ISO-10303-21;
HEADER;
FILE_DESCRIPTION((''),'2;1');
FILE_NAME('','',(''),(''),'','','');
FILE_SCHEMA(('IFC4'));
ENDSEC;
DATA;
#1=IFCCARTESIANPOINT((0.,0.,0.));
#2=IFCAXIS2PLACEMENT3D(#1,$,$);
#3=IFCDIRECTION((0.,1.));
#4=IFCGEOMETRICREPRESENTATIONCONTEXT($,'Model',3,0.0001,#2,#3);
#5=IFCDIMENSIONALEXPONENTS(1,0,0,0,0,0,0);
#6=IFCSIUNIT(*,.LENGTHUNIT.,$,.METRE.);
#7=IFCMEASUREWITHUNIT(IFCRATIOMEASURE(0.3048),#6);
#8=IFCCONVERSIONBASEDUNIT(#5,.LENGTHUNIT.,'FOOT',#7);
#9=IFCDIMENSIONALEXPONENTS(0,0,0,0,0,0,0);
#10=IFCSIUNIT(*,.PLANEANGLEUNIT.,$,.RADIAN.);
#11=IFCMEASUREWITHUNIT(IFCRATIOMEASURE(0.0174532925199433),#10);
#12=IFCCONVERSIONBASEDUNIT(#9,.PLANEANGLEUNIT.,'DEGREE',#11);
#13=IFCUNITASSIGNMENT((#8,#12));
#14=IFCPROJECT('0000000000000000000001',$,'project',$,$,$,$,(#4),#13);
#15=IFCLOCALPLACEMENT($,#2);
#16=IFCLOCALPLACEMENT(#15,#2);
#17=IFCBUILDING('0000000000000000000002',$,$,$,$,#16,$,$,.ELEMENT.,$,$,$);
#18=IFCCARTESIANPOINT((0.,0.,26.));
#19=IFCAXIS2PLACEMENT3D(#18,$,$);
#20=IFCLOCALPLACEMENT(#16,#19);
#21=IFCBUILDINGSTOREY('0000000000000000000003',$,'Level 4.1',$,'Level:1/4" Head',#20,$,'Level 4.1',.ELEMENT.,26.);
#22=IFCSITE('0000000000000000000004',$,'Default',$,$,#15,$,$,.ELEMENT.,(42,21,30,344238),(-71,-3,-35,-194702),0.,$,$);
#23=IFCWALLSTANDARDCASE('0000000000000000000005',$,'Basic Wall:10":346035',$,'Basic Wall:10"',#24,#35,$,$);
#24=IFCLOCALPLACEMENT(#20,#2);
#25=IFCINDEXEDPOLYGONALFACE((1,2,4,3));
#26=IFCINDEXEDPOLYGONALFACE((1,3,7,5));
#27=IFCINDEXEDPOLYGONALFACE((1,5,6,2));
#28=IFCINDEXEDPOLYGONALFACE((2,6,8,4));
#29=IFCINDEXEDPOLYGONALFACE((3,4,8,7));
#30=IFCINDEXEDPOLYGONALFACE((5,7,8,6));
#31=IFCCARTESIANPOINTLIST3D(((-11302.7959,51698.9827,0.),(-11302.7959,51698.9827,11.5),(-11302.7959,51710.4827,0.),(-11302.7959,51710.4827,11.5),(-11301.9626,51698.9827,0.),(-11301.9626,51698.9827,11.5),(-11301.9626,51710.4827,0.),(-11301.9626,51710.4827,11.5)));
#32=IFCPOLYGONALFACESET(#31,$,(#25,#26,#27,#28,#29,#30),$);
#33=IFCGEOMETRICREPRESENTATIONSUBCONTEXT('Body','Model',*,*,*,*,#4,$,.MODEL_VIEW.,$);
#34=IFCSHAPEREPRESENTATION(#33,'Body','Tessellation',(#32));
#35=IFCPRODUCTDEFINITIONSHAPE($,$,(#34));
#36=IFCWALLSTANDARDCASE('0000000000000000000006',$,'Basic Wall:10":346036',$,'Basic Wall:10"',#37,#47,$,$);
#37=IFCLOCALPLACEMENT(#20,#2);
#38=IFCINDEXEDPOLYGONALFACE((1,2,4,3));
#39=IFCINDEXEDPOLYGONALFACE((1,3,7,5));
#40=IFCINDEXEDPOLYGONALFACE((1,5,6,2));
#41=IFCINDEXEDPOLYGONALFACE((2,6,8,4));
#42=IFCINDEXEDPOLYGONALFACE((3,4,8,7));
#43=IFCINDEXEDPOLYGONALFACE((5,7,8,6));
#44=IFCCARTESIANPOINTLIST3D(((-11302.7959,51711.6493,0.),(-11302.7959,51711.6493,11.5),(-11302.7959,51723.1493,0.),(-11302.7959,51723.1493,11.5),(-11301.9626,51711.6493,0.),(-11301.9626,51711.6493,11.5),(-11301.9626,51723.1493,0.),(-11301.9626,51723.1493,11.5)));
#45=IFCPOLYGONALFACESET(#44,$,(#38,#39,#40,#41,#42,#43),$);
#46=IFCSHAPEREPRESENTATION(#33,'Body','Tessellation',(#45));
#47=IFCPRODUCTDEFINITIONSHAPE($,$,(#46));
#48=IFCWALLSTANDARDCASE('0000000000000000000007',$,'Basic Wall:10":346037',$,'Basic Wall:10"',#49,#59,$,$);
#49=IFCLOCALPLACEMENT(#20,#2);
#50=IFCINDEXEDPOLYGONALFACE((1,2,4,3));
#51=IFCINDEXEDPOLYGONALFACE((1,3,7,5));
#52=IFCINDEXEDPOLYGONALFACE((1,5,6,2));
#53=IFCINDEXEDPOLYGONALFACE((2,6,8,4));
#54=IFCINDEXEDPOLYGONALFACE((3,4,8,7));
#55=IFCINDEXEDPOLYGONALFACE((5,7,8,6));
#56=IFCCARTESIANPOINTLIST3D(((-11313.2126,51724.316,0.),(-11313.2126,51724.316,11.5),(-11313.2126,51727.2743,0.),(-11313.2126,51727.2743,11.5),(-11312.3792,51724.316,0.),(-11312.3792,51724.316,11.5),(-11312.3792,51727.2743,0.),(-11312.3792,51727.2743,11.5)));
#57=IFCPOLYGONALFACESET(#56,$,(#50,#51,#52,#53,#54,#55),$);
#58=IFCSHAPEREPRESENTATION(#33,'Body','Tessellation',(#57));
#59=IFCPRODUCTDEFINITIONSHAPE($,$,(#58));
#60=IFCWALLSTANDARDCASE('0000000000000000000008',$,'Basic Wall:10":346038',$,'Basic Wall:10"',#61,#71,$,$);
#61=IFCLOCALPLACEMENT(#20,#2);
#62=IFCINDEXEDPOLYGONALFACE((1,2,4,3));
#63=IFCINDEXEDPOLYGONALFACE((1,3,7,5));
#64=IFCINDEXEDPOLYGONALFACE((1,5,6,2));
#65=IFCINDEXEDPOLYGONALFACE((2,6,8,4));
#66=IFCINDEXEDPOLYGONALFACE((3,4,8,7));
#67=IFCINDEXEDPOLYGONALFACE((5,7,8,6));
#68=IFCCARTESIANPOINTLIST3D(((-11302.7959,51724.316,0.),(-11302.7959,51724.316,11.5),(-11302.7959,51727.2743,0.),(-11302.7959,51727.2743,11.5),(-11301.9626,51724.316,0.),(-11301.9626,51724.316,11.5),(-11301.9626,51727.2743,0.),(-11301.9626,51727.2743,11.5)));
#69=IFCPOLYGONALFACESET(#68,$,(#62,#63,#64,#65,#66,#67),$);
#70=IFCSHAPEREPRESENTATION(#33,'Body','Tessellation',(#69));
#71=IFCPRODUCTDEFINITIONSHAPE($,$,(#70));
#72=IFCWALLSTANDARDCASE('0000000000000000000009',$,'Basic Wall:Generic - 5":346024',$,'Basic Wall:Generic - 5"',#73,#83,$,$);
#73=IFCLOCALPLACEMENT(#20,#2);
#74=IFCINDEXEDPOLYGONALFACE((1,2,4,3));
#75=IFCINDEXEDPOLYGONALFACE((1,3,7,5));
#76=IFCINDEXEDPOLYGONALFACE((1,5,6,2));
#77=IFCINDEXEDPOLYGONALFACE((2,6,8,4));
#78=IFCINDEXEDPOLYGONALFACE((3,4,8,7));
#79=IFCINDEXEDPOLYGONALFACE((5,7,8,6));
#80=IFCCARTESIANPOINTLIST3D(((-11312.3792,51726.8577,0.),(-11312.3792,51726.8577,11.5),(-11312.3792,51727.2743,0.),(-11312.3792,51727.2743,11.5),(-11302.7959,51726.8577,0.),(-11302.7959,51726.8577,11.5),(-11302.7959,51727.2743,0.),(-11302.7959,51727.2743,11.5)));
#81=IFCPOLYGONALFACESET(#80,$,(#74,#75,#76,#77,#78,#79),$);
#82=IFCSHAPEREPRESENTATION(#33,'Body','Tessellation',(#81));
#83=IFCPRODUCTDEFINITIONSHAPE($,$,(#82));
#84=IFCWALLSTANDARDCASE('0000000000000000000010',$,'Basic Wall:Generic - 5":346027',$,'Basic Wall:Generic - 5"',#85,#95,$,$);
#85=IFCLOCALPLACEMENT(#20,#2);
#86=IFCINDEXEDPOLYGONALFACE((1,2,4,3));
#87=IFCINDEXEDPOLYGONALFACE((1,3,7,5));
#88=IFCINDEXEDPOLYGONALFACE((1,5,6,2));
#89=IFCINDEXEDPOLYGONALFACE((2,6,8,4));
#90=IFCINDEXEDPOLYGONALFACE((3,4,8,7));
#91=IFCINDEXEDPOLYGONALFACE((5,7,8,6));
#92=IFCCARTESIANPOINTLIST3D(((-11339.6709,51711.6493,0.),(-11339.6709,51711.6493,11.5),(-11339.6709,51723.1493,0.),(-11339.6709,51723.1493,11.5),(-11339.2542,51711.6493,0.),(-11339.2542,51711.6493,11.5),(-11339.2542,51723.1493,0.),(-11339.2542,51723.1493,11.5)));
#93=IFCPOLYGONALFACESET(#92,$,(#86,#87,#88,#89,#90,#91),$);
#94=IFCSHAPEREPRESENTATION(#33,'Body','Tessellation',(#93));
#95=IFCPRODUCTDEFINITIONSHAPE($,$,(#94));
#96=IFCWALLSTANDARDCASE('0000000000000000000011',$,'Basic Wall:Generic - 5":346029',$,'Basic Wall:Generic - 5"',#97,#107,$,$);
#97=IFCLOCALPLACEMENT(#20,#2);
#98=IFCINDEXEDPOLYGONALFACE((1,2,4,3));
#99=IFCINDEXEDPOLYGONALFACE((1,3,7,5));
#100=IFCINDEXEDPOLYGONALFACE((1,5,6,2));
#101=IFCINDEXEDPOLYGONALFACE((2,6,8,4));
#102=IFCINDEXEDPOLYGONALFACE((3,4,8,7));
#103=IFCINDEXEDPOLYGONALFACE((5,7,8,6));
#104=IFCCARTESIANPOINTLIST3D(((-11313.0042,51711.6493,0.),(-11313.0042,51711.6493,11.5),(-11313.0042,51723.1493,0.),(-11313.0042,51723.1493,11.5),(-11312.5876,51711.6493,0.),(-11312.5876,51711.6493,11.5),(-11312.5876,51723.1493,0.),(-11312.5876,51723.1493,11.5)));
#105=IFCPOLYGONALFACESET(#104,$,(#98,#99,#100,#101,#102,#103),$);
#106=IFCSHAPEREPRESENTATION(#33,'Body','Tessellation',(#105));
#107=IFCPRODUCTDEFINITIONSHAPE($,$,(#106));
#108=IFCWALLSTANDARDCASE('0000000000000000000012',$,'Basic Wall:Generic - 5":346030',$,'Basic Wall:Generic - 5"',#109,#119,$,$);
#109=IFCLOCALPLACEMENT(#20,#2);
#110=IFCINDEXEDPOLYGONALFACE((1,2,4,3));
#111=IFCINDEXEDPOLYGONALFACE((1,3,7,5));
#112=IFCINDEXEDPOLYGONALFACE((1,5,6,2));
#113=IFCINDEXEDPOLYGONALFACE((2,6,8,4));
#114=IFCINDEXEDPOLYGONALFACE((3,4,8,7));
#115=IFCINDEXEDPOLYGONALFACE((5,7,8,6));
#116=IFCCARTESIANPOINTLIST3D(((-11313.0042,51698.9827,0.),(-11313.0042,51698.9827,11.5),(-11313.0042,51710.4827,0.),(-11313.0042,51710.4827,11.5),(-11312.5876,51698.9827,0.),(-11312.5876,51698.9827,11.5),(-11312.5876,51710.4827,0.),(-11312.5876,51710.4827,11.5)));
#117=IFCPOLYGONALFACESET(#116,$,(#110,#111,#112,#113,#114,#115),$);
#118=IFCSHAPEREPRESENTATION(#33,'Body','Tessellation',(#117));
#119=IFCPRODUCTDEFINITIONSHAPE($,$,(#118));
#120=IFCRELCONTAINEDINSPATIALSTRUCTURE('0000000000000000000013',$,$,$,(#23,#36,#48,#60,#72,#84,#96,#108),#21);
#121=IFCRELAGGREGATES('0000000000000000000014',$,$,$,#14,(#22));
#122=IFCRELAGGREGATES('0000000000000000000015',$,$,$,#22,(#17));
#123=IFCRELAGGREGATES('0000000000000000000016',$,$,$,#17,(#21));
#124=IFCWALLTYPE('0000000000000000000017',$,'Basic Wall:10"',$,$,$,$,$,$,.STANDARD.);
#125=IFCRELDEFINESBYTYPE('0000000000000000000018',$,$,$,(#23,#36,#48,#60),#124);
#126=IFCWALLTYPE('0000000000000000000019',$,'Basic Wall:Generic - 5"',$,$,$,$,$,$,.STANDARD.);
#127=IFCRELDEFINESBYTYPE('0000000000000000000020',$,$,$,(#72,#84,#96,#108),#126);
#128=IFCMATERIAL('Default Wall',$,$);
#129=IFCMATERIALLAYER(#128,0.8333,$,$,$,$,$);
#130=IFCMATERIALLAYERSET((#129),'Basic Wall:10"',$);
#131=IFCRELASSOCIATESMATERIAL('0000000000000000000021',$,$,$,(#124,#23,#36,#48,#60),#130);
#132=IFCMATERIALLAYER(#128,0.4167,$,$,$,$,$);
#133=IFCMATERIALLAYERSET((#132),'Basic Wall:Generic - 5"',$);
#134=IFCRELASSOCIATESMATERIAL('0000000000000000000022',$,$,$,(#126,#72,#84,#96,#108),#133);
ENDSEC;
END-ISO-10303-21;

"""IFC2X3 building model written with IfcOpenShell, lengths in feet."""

from ifc_helpers import new_model, entity, si_unit, converted_unit, direction, frame, frame_2d, origin, place, context, subcontext, project, spatial, rectangle, extrude, material, layer, layer_set, layer_usage, type_object, element, save


model = new_model("IFC2X3")

# Units and contexts
model_context = context("Model", 3, precision=0.0001, world=origin(), true_north=direction((0.0, 1.0)))
body_context = subcontext(model_context, "Body", "Model", "MODEL_VIEW")
ifc_project = project(units=[converted_unit("LENGTHUNIT", "FOOT", entity("IfcRatioMeasure", 0.3048), si_unit("LENGTHUNIT", "METRE"), dimensions=[1, 0, 0, 0, 0, 0, 0]), converted_unit("PLANEANGLEUNIT", "DEGREE", entity("IfcRatioMeasure", 0.0174532925199433), si_unit("PLANEANGLEUNIT", "RADIAN"), dimensions=[0, 0, 0, 0, 0, 0, 0])], contexts=[model_context])

# Site, building, storey
site_placement = place(None, origin())
site = spatial("IfcSite", under=ifc_project, at=site_placement, Name="Default", CompositionType="ELEMENT", RefLatitude=(42, 21, 30, 344238), RefLongitude=(-71, -3, -35, -194702), RefElevation=0.0)
building_placement = place(site_placement, origin())
building = spatial("IfcBuilding", under=site, at=building_placement, CompositionType="ELEMENT")
storey_placement = place(building_placement, frame((0.0, 0.0, 26.0)))
storey = spatial("IfcBuildingStorey", under=building, at=storey_placement, Name="Level 4.1", ObjectType="Level:1/4\" Head", LongName="Level 4.1", CompositionType="ELEMENT", Elevation=26.0)

# Walls
ifc_material_1 = material(Name="Default Wall")
ifc_layer_1 = layer(ifc_material_1, 0.8333)
ifc_layer_set_1 = layer_set([ifc_layer_1], Name="Basic Wall:10\"")
ifc_layer_usage_1 = layer_usage(ifc_layer_set_1, "AXIS2", "NEGATIVE", 0.4167)
wall_type_1 = type_object("IfcWallType", Name="Basic Wall:10\"", PredefinedType="STANDARD", material=ifc_layer_set_1)
wall_1_placement = place(storey_placement, frame((-11302.3792, 51698.9827, 0.0), z_axis=(0.0, 0.0, 1.0), x_axis=(0.0, 1.0, 0.0)))
element("IfcWallStandardCase", 1, at=wall_1_placement, inside=storey, type_object=wall_type_1, material=ifc_layer_usage_1, Name="Basic Wall:10\":346035", ObjectType="Basic Wall:10\"", context=body_context, shape_type="SweptSolid", body=[
    extrude(rectangle(XDim=11.5, YDim=0.8333, at=frame_2d((5.75, 0.0), x_axis=(-1.0, 0.0))), origin(), (0.0, 0.0, 1.0), 11.5),
])
ifc_layer_usage_2 = layer_usage(ifc_layer_set_1, "AXIS2", "NEGATIVE", 0.4167)
wall_2_placement = place(storey_placement, frame((-11302.3792, 51711.6493, 0.0), z_axis=(0.0, 0.0, 1.0), x_axis=(0.0, 1.0, 0.0)))
element("IfcWallStandardCase", 2, at=wall_2_placement, inside=storey, type_object=wall_type_1, material=ifc_layer_usage_2, Name="Basic Wall:10\":346036", ObjectType="Basic Wall:10\"", context=body_context, shape_type="SweptSolid", body=[
    extrude(rectangle(XDim=11.5, YDim=0.8333, at=frame_2d((5.75, 0.0), x_axis=(-1.0, 0.0))), origin(), (0.0, 0.0, 1.0), 11.5),
])
ifc_layer_usage_3 = layer_usage(ifc_layer_set_1, "AXIS2", "NEGATIVE", 0.4167)
wall_3_placement = place(storey_placement, frame((-11312.7959, 51724.316, 0.0), z_axis=(0.0, 0.0, 1.0), x_axis=(0.0, 1.0, 0.0)))
element("IfcWallStandardCase", 3, at=wall_3_placement, inside=storey, type_object=wall_type_1, material=ifc_layer_usage_3, Name="Basic Wall:10\":346037", ObjectType="Basic Wall:10\"", context=body_context, shape_type="SweptSolid", body=[
    extrude(rectangle(XDim=2.9583, YDim=0.8333, at=frame_2d((1.4792, 0.0), x_axis=(-1.0, 0.0))), origin(), (0.0, 0.0, 1.0), 11.5),
])
ifc_layer_usage_4 = layer_usage(ifc_layer_set_1, "AXIS2", "NEGATIVE", 0.4167)
wall_4_placement = place(storey_placement, frame((-11302.3792, 51724.316, 0.0), z_axis=(0.0, 0.0, 1.0), x_axis=(0.0, 1.0, 0.0)))
element("IfcWallStandardCase", 4, at=wall_4_placement, inside=storey, type_object=wall_type_1, material=ifc_layer_usage_4, Name="Basic Wall:10\":346038", ObjectType="Basic Wall:10\"", context=body_context, shape_type="SweptSolid", body=[
    extrude(rectangle(XDim=2.9583, YDim=0.8333, at=frame_2d((1.4792, 0.0), x_axis=(-1.0, 0.0))), origin(), (0.0, 0.0, 1.0), 11.5),
])

# Shared definitions
ifc_layer_2 = layer(ifc_material_1, 0.4167)
ifc_layer_set_2 = layer_set([ifc_layer_2], Name="Basic Wall:Generic - 5\"")
wall_type_2 = type_object("IfcWallType", Name="Basic Wall:Generic - 5\"", PredefinedType="STANDARD", material=ifc_layer_set_2)

# Walls
ifc_layer_usage_5 = layer_usage(ifc_layer_set_2, "AXIS2", "NEGATIVE", 0.2083)
wall_5_placement = place(storey_placement, frame((-11312.3792, 51727.066, 0.0)))
element("IfcWallStandardCase", 5, at=wall_5_placement, inside=storey, type_object=wall_type_2, material=ifc_layer_usage_5, Name="Basic Wall:Generic - 5\":346024", ObjectType="Basic Wall:Generic - 5\"", context=body_context, shape_type="SweptSolid", body=[
    extrude(rectangle(XDim=9.5833, YDim=0.4167, at=frame_2d((4.7917, 0.0), x_axis=(-1.0, 0.0))), origin(), (0.0, 0.0, 1.0), 11.5),
])
ifc_layer_usage_6 = layer_usage(ifc_layer_set_2, "AXIS2", "NEGATIVE", 0.2083)
wall_6_placement = place(storey_placement, frame((-11339.4626, 51723.1493, 0.0), z_axis=(0.0, 0.0, 1.0), x_axis=(0.0, -1.0, 0.0)))
element("IfcWallStandardCase", 6, at=wall_6_placement, inside=storey, type_object=wall_type_2, material=ifc_layer_usage_6, Name="Basic Wall:Generic - 5\":346027", ObjectType="Basic Wall:Generic - 5\"", context=body_context, shape_type="SweptSolid", body=[
    extrude(rectangle(XDim=11.5, YDim=0.4167, at=frame_2d((5.75, 0.0), x_axis=(-1.0, 0.0))), origin(), (0.0, 0.0, 1.0), 11.5),
])
ifc_layer_usage_7 = layer_usage(ifc_layer_set_2, "AXIS2", "NEGATIVE", 0.2083)
wall_7_placement = place(storey_placement, frame((-11312.7959, 51723.1493, 0.0), z_axis=(0.0, 0.0, 1.0), x_axis=(0.0, -1.0, 0.0)))
element("IfcWallStandardCase", 7, at=wall_7_placement, inside=storey, type_object=wall_type_2, material=ifc_layer_usage_7, Name="Basic Wall:Generic - 5\":346029", ObjectType="Basic Wall:Generic - 5\"", context=body_context, shape_type="SweptSolid", body=[
    extrude(rectangle(XDim=11.5, YDim=0.4167, at=frame_2d((5.75, 0.0), x_axis=(-1.0, 0.0))), origin(), (0.0, 0.0, 1.0), 11.5),
])
ifc_layer_usage_8 = layer_usage(ifc_layer_set_2, "AXIS2", "NEGATIVE", 0.2083)
wall_8_placement = place(storey_placement, frame((-11312.7959, 51710.4827, 0.0), z_axis=(0.0, 0.0, 1.0), x_axis=(0.0, -1.0, 0.0)))
element("IfcWallStandardCase", 8, at=wall_8_placement, inside=storey, type_object=wall_type_2, material=ifc_layer_usage_8, Name="Basic Wall:Generic - 5\":346030", ObjectType="Basic Wall:Generic - 5\"", context=body_context, shape_type="SweptSolid", body=[
    extrude(rectangle(XDim=11.5, YDim=0.4167, at=frame_2d((5.75, 0.0), x_axis=(-1.0, 0.0))), origin(), (0.0, 0.0, 1.0), 11.5),
])

save(model, "model.ifc")
